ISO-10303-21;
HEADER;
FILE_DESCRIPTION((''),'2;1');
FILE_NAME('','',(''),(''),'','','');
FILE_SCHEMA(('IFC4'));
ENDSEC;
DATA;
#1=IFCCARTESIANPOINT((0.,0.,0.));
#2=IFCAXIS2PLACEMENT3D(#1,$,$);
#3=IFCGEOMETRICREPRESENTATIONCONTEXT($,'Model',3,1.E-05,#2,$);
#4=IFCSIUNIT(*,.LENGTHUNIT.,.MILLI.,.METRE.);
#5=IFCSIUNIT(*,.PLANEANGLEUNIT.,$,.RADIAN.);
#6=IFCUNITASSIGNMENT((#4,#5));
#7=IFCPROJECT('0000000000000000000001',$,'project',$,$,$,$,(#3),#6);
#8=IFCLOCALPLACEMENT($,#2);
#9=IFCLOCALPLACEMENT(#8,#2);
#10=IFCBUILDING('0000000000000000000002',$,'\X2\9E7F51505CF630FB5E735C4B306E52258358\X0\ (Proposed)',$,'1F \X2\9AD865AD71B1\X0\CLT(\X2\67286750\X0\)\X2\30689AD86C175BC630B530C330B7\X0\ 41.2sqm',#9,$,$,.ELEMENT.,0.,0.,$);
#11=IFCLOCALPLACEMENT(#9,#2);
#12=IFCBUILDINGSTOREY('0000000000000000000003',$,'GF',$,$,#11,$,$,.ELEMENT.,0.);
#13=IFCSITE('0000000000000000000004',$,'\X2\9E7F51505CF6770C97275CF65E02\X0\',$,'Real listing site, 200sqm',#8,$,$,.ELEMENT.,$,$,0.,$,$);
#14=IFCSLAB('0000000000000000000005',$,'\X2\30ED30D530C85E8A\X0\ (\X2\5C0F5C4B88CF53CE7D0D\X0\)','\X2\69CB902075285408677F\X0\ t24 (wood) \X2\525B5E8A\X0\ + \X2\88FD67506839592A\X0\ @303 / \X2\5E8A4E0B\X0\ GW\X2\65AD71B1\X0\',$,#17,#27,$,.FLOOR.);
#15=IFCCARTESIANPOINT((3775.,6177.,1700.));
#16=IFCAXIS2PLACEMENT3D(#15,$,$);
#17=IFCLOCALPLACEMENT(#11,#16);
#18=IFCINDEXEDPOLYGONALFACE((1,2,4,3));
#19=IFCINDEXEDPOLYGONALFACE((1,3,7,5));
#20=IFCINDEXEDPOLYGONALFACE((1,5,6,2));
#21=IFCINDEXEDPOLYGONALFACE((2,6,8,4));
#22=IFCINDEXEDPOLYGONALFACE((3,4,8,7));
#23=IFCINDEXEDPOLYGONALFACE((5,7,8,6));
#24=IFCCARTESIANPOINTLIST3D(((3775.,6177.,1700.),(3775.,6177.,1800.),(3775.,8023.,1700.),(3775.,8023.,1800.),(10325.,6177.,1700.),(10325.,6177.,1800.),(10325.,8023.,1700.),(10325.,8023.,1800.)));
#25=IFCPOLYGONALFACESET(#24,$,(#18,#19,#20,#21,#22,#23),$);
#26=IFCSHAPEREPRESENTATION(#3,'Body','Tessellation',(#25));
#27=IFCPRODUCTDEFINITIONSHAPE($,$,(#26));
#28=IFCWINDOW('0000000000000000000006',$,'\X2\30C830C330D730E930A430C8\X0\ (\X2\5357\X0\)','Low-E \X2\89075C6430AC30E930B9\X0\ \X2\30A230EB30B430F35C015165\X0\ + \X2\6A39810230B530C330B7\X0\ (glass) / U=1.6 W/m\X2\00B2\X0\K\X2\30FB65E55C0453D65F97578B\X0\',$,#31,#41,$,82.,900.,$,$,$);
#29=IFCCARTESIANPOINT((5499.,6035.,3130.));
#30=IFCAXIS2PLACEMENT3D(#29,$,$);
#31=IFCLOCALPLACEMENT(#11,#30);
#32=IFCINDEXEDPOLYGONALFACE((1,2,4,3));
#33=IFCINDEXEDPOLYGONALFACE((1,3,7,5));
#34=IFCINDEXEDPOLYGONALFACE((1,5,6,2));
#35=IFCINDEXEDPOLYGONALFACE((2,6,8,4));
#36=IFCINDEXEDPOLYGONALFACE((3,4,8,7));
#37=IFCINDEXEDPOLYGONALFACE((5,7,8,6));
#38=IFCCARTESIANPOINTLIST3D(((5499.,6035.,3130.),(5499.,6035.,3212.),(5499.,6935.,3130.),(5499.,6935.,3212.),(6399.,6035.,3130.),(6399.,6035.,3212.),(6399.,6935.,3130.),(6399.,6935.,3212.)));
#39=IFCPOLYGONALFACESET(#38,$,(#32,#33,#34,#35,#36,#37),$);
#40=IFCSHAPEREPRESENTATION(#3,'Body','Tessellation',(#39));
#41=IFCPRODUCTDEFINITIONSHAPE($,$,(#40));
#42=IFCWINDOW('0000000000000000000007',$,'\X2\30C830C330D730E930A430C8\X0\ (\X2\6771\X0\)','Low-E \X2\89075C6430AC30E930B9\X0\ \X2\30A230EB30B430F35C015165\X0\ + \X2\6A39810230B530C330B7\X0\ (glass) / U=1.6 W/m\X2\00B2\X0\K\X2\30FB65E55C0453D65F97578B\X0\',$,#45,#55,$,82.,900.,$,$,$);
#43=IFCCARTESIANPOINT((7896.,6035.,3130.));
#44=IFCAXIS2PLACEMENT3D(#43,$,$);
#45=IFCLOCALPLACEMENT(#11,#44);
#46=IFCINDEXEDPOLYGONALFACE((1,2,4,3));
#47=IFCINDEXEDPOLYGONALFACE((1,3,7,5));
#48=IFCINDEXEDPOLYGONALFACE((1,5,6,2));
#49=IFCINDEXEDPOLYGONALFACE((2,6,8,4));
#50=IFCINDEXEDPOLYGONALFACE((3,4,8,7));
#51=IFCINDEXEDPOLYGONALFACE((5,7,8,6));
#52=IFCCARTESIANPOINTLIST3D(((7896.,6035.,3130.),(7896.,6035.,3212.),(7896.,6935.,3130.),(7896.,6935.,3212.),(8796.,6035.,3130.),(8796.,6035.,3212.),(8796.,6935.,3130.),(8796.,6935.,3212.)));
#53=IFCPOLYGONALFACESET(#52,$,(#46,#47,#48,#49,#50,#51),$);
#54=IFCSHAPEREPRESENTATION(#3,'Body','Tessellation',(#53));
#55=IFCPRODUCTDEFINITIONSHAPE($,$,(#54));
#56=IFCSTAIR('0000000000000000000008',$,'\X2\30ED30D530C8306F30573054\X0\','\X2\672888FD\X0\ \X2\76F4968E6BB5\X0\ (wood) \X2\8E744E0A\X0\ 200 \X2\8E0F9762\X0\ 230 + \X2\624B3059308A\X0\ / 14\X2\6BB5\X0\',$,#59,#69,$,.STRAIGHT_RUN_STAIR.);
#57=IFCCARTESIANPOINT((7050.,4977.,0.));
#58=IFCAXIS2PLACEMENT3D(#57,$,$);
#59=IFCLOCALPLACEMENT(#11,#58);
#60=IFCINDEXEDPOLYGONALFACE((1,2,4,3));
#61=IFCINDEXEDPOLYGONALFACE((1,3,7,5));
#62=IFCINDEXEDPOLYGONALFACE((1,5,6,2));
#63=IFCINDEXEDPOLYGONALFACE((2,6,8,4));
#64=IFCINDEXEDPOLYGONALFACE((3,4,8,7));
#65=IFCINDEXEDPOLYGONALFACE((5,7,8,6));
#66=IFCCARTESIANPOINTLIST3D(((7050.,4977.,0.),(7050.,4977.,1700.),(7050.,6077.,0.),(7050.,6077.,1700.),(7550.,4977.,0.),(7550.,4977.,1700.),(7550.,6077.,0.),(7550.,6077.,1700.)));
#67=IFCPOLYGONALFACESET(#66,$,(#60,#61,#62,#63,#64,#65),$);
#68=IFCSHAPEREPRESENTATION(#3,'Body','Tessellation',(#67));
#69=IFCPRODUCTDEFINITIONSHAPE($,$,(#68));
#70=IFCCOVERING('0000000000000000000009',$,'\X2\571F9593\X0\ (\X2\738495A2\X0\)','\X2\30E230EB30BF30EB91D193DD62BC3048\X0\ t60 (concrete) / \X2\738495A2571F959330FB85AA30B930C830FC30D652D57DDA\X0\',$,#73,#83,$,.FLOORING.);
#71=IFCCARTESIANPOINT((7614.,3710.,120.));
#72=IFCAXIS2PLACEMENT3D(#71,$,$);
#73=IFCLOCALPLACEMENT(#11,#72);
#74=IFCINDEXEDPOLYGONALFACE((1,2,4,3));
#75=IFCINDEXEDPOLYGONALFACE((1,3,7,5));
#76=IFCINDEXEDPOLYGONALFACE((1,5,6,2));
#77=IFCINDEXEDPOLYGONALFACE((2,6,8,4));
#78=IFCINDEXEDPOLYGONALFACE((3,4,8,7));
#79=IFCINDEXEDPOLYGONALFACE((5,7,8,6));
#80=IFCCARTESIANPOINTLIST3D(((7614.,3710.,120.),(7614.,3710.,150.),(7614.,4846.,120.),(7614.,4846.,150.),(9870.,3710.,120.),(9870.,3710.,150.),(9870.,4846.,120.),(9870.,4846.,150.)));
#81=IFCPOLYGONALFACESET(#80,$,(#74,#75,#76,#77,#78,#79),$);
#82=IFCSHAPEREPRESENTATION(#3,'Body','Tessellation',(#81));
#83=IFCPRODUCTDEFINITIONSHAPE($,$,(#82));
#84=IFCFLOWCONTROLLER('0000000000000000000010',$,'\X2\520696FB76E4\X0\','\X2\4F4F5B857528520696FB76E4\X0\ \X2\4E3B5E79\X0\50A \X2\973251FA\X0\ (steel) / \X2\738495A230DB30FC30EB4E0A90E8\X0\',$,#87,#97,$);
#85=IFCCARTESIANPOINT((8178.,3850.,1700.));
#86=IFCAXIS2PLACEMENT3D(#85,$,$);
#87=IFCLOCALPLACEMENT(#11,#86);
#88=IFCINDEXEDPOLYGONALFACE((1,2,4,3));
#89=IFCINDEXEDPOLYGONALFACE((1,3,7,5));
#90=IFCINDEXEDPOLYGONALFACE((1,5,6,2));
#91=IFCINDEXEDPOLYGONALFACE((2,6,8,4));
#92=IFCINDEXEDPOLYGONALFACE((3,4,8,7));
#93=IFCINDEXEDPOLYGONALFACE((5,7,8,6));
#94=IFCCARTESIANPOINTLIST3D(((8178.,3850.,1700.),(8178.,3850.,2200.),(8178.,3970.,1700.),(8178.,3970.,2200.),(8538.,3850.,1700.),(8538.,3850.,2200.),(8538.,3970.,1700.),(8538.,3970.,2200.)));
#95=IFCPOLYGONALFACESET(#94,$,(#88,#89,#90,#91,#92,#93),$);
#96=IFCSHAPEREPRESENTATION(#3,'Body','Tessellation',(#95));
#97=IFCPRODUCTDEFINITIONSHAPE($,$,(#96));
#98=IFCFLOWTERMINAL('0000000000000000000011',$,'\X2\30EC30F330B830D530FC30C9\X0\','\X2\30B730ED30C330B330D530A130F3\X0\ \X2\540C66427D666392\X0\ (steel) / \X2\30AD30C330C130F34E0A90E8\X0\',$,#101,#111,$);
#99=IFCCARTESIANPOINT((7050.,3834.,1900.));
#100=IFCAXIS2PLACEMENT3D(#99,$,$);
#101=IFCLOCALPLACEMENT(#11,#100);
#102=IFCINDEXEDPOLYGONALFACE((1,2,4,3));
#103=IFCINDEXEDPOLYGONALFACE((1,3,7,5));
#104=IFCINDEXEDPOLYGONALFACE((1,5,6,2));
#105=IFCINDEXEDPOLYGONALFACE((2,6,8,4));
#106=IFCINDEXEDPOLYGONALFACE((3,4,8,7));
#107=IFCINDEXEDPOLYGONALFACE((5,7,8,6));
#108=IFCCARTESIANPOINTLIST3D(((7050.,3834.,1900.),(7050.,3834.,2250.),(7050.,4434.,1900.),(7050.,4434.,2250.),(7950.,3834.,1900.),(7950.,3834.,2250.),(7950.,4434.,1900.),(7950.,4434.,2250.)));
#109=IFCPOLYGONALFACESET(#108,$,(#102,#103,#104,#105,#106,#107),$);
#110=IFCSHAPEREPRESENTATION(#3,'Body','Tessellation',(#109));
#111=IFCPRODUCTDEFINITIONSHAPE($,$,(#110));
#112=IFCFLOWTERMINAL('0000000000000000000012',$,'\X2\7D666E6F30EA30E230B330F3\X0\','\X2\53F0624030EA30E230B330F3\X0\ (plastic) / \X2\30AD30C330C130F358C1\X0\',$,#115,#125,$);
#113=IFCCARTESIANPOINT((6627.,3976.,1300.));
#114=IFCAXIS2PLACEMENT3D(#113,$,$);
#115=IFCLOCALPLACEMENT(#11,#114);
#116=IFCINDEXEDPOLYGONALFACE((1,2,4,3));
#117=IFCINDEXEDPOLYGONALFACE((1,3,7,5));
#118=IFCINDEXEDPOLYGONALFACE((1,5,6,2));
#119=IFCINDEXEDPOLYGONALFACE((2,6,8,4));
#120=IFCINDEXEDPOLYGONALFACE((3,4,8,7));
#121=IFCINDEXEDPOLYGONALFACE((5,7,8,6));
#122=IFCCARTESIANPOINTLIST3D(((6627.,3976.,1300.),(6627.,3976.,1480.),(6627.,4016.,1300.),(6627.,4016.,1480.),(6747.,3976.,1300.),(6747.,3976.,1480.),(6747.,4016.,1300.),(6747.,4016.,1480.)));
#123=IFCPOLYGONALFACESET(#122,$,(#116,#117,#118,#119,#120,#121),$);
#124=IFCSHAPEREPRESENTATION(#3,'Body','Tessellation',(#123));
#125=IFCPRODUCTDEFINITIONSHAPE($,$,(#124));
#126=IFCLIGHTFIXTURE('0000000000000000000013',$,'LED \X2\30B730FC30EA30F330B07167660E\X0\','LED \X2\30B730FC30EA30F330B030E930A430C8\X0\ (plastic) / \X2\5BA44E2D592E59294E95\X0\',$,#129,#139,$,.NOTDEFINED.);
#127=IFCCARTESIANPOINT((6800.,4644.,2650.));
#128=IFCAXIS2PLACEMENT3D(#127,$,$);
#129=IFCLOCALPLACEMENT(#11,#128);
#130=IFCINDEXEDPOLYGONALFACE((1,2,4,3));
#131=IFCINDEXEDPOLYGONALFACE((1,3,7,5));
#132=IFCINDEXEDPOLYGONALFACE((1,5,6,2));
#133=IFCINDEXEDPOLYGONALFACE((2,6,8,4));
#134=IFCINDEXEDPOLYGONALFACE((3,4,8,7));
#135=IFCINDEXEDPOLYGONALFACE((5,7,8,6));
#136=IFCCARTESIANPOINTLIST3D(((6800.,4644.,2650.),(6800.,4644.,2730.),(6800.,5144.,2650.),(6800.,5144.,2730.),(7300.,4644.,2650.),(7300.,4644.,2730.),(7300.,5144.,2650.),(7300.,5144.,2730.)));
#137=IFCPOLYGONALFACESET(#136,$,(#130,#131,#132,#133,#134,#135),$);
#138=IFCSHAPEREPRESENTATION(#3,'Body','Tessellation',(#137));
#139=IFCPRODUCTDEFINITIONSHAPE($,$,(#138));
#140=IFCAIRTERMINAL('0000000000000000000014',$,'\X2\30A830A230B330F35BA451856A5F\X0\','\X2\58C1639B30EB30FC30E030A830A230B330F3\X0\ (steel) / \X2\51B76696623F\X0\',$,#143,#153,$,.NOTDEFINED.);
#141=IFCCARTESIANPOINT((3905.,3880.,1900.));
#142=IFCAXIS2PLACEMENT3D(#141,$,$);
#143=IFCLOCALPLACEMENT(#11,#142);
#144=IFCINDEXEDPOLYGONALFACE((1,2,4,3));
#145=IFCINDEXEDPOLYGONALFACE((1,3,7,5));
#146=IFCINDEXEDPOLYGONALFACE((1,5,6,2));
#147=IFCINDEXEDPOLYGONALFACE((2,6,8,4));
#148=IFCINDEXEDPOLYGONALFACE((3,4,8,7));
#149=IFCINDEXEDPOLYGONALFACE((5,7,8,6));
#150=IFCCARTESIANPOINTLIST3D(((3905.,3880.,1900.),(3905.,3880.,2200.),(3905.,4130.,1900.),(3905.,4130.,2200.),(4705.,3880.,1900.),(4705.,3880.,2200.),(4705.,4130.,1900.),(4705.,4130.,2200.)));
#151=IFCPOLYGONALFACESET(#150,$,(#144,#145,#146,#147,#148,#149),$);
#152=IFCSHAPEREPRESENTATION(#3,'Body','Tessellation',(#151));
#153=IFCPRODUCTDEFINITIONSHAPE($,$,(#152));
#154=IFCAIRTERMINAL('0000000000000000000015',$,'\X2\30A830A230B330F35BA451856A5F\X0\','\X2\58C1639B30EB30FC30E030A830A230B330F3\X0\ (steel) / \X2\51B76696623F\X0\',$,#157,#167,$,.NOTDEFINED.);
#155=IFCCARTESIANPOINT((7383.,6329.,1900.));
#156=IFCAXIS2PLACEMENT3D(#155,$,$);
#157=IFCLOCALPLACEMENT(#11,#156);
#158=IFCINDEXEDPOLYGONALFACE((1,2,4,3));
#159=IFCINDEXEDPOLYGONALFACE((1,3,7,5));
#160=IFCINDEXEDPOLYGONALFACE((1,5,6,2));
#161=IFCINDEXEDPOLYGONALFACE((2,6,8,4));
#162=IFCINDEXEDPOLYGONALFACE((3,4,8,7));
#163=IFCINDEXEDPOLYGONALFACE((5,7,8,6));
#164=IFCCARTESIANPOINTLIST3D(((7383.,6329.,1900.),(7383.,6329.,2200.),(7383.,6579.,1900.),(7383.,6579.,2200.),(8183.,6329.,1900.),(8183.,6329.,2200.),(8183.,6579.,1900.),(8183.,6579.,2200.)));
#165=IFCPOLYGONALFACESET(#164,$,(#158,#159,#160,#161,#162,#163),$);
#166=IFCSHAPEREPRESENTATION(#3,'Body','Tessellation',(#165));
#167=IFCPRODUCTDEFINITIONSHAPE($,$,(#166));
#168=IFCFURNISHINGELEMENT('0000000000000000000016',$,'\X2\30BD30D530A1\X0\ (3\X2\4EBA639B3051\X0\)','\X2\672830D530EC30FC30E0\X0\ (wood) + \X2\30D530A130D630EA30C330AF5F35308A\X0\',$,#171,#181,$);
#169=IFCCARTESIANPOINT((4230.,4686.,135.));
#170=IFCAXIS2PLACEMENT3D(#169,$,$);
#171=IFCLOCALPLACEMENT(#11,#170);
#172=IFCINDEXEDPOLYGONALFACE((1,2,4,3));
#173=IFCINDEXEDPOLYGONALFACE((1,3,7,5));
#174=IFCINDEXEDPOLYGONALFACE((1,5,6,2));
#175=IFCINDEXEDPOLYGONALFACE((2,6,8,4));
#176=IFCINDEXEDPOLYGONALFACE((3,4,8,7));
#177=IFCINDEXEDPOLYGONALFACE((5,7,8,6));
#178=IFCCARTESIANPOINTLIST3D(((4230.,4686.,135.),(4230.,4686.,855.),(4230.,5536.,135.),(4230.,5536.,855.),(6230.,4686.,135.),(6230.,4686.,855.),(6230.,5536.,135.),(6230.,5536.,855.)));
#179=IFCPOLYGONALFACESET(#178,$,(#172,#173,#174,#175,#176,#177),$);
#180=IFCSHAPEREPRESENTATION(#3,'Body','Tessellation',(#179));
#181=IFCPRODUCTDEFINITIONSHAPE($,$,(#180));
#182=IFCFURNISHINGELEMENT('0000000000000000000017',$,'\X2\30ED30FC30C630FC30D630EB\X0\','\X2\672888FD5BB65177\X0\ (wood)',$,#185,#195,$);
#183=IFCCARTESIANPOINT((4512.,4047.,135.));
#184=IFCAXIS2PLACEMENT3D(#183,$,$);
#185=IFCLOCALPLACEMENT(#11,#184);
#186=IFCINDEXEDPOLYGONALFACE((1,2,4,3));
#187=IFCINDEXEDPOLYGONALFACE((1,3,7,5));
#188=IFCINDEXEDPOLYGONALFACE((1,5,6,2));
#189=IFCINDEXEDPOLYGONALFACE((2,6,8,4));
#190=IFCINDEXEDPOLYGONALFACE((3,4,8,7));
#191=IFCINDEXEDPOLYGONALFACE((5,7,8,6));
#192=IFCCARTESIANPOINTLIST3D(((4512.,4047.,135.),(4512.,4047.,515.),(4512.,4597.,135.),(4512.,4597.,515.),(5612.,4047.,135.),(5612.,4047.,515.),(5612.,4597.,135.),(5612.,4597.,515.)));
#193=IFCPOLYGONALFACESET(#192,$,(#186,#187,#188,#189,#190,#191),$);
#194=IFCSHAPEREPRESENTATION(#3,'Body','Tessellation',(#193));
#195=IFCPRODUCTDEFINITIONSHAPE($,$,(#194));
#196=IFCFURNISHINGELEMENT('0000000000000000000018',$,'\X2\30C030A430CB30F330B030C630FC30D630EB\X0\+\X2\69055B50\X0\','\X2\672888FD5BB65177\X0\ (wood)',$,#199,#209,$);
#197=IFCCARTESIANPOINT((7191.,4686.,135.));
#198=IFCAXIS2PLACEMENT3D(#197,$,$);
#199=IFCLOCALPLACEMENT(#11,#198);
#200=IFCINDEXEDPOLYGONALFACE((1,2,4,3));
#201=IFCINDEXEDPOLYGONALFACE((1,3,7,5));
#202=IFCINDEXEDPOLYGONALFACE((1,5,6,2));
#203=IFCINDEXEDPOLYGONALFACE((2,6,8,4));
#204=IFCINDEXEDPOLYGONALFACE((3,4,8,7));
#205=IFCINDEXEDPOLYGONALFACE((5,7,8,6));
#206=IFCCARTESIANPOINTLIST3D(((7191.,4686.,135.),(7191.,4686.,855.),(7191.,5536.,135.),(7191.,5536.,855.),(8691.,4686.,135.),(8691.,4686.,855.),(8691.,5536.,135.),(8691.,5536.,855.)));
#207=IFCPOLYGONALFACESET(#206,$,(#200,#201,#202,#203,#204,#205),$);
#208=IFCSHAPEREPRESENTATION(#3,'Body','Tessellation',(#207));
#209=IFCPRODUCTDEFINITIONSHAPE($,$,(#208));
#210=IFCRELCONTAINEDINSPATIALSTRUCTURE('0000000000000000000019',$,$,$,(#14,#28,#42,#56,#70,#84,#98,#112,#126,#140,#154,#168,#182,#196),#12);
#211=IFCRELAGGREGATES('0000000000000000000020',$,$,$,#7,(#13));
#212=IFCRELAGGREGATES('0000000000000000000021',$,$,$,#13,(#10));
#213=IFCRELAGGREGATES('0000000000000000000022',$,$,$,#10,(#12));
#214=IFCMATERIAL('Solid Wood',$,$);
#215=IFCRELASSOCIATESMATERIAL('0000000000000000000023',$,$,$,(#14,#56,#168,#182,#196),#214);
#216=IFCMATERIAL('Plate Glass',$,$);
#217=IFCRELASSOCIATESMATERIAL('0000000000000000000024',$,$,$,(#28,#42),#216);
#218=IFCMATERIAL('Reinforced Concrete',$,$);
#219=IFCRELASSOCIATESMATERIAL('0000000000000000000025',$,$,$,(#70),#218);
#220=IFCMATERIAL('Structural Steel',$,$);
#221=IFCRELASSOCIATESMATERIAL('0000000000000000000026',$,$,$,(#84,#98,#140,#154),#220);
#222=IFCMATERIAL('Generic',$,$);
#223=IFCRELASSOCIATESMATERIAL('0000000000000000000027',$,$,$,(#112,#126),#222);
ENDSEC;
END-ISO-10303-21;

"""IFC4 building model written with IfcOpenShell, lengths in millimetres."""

from ifc_helpers import new_model, si_unit, frame, frame_2d, origin, place, context, project, spatial, rectangle, extrude, material, element, save


model = new_model("IFC4")

# Units and contexts
model_context = context("Model", 3, precision=1e-05, world=origin())
ifc_project = project(units=[si_unit("LENGTHUNIT", "METRE", prefix="MILLI"), si_unit("PLANEANGLEUNIT", "RADIAN")], contexts=[model_context])

# Site, building, storey
site_placement = place(None, origin())
site = spatial("IfcSite", under=ifc_project, at=site_placement, Name="鹿児島県霧島市", ObjectType="Real listing site, 200sqm", CompositionType="ELEMENT", RefElevation=0.0)
building_placement = place(site_placement, origin())
building = spatial("IfcBuilding", under=site, at=building_placement, Name="鹿児島・平屋の別荘 (Proposed)", ObjectType="1F 高断熱CLT(木材)と高気密サッシ 41.2sqm", CompositionType="ELEMENT", ElevationOfRefHeight=0.0, ElevationOfTerrain=0.0)
storey_placement = place(building_placement, origin())
storey = spatial("IfcBuildingStorey", under=building, at=storey_placement, Name="GF", CompositionType="ELEMENT", Elevation=0.0)

# Shared definitions
ifc_material_1 = material(Name="Solid Wood")

# Slab
slab_placement = place(storey_placement, frame((3775.0, 6177.0, 1700.0)))
element("IfcSlab", 1, at=slab_placement, inside=storey, material=ifc_material_1, Name="ロフト床 (小屋裏収納)", Description="構造用合板 t24 (wood) 剛床 + 製材根太 @303 / 床下 GW断熱", PredefinedType="FLOOR", context=model_context, shape_type="SweptSolid", body=[
    extrude(rectangle(XDim=6550.0, YDim=1846.0, at=frame_2d((3275.0, 923.0))), frame((3775.0, 6177.0, 1700.0)), (0.0, 0.0, 1.0), 100.0),
])

# Windows
ifc_material_2 = material(Name="Plate Glass")
window_1_placement = place(storey_placement, frame((5499.0, 6035.0, 3130.0)))
element("IfcWindow", 2, at=window_1_placement, inside=storey, material=ifc_material_2, Name="トップライト (南)", Description="Low-E 複層ガラス アルゴン封入 + 樹脂サッシ (glass) / U=1.6 W/m²K・日射取得型", OverallHeight=82.0, OverallWidth=900.0, context=model_context, shape_type="SweptSolid", body=[
    extrude(rectangle(XDim=900.0, YDim=900.0, at=frame_2d((450.0, 450.0))), frame((5499.0, 6035.0, 3130.0)), (0.0, 0.0, 1.0), 82.0),
])
window_2_placement = place(storey_placement, frame((7896.0, 6035.0, 3130.0)))
element("IfcWindow", 3, at=window_2_placement, inside=storey, material=ifc_material_2, Name="トップライト (東)", Description="Low-E 複層ガラス アルゴン封入 + 樹脂サッシ (glass) / U=1.6 W/m²K・日射取得型", OverallHeight=82.0, OverallWidth=900.0, context=model_context, shape_type="SweptSolid", body=[
    extrude(rectangle(XDim=900.0, YDim=900.0, at=frame_2d((450.0, 450.0))), frame((7896.0, 6035.0, 3130.0)), (0.0, 0.0, 1.0), 82.0),
])

# Stair
stair_placement = place(storey_placement, frame((7050.0, 4977.0, 0.0)))
element("IfcStair", 4, at=stair_placement, inside=storey, material=ifc_material_1, Name="ロフトはしご", Description="木製 直階段 (wood) 蹴上 200 踏面 230 + 手すり / 14段", PredefinedType="STRAIGHT_RUN_STAIR", context=model_context, shape_type="SweptSolid", body=[
    extrude(rectangle(XDim=500.0, YDim=1100.0, at=frame_2d((250.0, 550.0))), frame((7050.0, 4977.0, 0.0)), (0.0, 0.0, 1.0), 1700.0),
])

# Covering
ifc_material_3 = material(Name="Reinforced Concrete")
covering_placement = place(storey_placement, frame((7614.0, 3710.0, 120.0)))
element("IfcCovering", 5, at=covering_placement, inside=storey, material=ifc_material_3, Name="土間 (玄関)", Description="モルタル金鏝押え t60 (concrete) / 玄関土間・薪ストーブ動線", PredefinedType="FLOORING", context=model_context, shape_type="SweptSolid", body=[
    extrude(rectangle(XDim=2256.0, YDim=1136.0, at=frame_2d((1128.0, 568.0))), frame((7614.0, 3710.0, 120.0)), (0.0, 0.0, 1.0), 30.0),
])

# Flow controller
ifc_material_4 = material(Name="Structural Steel")
flow_controller_placement = place(storey_placement, frame((8178.0, 3850.0, 1700.0)))
element("IfcFlowController", 6, at=flow_controller_placement, inside=storey, material=ifc_material_4, Name="分電盤", Description="住宅用分電盤 主幹50A 露出 (steel) / 玄関ホール上部", context=model_context, shape_type="SweptSolid", body=[
    extrude(rectangle(XDim=360.0, YDim=120.0, at=frame_2d((180.0, 60.0))), frame((8178.0, 3850.0, 1700.0)), (0.0, 0.0, 1.0), 500.0),
])

# Flow terminals
flow_terminal_1_placement = place(storey_placement, frame((7050.0, 3834.0, 1900.0)))
element("IfcFlowTerminal", 7, at=flow_terminal_1_placement, inside=storey, material=ifc_material_4, Name="レンジフード", Description="シロッコファン 同時給排 (steel) / キッチン上部", context=model_context, shape_type="SweptSolid", body=[
    extrude(rectangle(XDim=900.0, YDim=600.0, at=frame_2d((450.0, 300.0))), frame((7050.0, 3834.0, 1900.0)), (0.0, 0.0, 1.0), 350.0),
])
ifc_material_5 = material(Name="Generic")
flow_terminal_2_placement = place(storey_placement, frame((6627.0, 3976.0, 1300.0)))
element("IfcFlowTerminal", 8, at=flow_terminal_2_placement, inside=storey, material=ifc_material_5, Name="給湯リモコン", Description="台所リモコン (plastic) / キッチン壁", context=model_context, shape_type="SweptSolid", body=[
    extrude(rectangle(XDim=120.0, YDim=40.0, at=frame_2d((60.0, 20.0))), frame((6627.0, 3976.0, 1300.0)), (0.0, 0.0, 1.0), 180.0),
])

# Light fixture
light_fixture_placement = place(storey_placement, frame((6800.0, 4644.0, 2650.0)))
element("IfcLightFixture", 9, at=light_fixture_placement, inside=storey, material=ifc_material_5, Name="LED シーリング照明", Description="LED シーリングライト (plastic) / 室中央天井", PredefinedType="NOTDEFINED", context=model_context, shape_type="SweptSolid", body=[
    extrude(rectangle(XDim=500.0, YDim=500.0, at=frame_2d((250.0, 250.0))), frame((6800.0, 4644.0, 2650.0)), (0.0, 0.0, 1.0), 80.0),
])

# Air terminals
air_terminal_1_placement = place(storey_placement, frame((3905.0, 3880.0, 1900.0)))
element("IfcAirTerminal", 10, at=air_terminal_1_placement, inside=storey, material=ifc_material_4, Name="エアコン室内機", Description="壁掛ルームエアコン (steel) / 冷暖房", PredefinedType="NOTDEFINED", context=model_context, shape_type="SweptSolid", body=[
    extrude(rectangle(XDim=800.0, YDim=250.0, at=frame_2d((400.0, 125.0))), frame((3905.0, 3880.0, 1900.0)), (0.0, 0.0, 1.0), 300.0),
])
air_terminal_2_placement = place(storey_placement, frame((7383.0, 6329.0, 1900.0)))
element("IfcAirTerminal", 11, at=air_terminal_2_placement, inside=storey, material=ifc_material_4, Name="エアコン室内機", Description="壁掛ルームエアコン (steel) / 冷暖房", PredefinedType="NOTDEFINED", context=model_context, shape_type="SweptSolid", body=[
    extrude(rectangle(XDim=800.0, YDim=250.0, at=frame_2d((400.0, 125.0))), frame((7383.0, 6329.0, 1900.0)), (0.0, 0.0, 1.0), 300.0),
])

# Furnishing elements
furnishing_1_placement = place(storey_placement, frame((4230.0, 4686.0, 135.0)))
element("IfcFurnishingElement", 12, at=furnishing_1_placement, inside=storey, material=ifc_material_1, Name="ソファ (3人掛け)", Description="木フレーム (wood) + ファブリック張り", context=model_context, shape_type="SweptSolid", body=[
    extrude(rectangle(XDim=2000.0, YDim=850.0, at=frame_2d((1000.0, 425.0))), frame((4230.0, 4686.0, 135.0)), (0.0, 0.0, 1.0), 720.0),
])
furnishing_2_placement = place(storey_placement, frame((4512.0, 4047.0, 135.0)))
element("IfcFurnishingElement", 13, at=furnishing_2_placement, inside=storey, material=ifc_material_1, Name="ローテーブル", Description="木製家具 (wood)", context=model_context, shape_type="SweptSolid", body=[
    extrude(rectangle(XDim=1100.0, YDim=550.0, at=frame_2d((550.0, 275.0))), frame((4512.0, 4047.0, 135.0)), (0.0, 0.0, 1.0), 380.0),
])
furnishing_3_placement = place(storey_placement, frame((7191.0, 4686.0, 135.0)))
element("IfcFurnishingElement", 14, at=furnishing_3_placement, inside=storey, material=ifc_material_1, Name="ダイニングテーブル+椅子", Description="木製家具 (wood)", context=model_context, shape_type="SweptSolid", body=[
    extrude(rectangle(XDim=1500.0, YDim=850.0, at=frame_2d((750.0, 425.0))), frame((7191.0, 4686.0, 135.0)), (0.0, 0.0, 1.0), 720.0),
])

save(model, "model.ifc")
